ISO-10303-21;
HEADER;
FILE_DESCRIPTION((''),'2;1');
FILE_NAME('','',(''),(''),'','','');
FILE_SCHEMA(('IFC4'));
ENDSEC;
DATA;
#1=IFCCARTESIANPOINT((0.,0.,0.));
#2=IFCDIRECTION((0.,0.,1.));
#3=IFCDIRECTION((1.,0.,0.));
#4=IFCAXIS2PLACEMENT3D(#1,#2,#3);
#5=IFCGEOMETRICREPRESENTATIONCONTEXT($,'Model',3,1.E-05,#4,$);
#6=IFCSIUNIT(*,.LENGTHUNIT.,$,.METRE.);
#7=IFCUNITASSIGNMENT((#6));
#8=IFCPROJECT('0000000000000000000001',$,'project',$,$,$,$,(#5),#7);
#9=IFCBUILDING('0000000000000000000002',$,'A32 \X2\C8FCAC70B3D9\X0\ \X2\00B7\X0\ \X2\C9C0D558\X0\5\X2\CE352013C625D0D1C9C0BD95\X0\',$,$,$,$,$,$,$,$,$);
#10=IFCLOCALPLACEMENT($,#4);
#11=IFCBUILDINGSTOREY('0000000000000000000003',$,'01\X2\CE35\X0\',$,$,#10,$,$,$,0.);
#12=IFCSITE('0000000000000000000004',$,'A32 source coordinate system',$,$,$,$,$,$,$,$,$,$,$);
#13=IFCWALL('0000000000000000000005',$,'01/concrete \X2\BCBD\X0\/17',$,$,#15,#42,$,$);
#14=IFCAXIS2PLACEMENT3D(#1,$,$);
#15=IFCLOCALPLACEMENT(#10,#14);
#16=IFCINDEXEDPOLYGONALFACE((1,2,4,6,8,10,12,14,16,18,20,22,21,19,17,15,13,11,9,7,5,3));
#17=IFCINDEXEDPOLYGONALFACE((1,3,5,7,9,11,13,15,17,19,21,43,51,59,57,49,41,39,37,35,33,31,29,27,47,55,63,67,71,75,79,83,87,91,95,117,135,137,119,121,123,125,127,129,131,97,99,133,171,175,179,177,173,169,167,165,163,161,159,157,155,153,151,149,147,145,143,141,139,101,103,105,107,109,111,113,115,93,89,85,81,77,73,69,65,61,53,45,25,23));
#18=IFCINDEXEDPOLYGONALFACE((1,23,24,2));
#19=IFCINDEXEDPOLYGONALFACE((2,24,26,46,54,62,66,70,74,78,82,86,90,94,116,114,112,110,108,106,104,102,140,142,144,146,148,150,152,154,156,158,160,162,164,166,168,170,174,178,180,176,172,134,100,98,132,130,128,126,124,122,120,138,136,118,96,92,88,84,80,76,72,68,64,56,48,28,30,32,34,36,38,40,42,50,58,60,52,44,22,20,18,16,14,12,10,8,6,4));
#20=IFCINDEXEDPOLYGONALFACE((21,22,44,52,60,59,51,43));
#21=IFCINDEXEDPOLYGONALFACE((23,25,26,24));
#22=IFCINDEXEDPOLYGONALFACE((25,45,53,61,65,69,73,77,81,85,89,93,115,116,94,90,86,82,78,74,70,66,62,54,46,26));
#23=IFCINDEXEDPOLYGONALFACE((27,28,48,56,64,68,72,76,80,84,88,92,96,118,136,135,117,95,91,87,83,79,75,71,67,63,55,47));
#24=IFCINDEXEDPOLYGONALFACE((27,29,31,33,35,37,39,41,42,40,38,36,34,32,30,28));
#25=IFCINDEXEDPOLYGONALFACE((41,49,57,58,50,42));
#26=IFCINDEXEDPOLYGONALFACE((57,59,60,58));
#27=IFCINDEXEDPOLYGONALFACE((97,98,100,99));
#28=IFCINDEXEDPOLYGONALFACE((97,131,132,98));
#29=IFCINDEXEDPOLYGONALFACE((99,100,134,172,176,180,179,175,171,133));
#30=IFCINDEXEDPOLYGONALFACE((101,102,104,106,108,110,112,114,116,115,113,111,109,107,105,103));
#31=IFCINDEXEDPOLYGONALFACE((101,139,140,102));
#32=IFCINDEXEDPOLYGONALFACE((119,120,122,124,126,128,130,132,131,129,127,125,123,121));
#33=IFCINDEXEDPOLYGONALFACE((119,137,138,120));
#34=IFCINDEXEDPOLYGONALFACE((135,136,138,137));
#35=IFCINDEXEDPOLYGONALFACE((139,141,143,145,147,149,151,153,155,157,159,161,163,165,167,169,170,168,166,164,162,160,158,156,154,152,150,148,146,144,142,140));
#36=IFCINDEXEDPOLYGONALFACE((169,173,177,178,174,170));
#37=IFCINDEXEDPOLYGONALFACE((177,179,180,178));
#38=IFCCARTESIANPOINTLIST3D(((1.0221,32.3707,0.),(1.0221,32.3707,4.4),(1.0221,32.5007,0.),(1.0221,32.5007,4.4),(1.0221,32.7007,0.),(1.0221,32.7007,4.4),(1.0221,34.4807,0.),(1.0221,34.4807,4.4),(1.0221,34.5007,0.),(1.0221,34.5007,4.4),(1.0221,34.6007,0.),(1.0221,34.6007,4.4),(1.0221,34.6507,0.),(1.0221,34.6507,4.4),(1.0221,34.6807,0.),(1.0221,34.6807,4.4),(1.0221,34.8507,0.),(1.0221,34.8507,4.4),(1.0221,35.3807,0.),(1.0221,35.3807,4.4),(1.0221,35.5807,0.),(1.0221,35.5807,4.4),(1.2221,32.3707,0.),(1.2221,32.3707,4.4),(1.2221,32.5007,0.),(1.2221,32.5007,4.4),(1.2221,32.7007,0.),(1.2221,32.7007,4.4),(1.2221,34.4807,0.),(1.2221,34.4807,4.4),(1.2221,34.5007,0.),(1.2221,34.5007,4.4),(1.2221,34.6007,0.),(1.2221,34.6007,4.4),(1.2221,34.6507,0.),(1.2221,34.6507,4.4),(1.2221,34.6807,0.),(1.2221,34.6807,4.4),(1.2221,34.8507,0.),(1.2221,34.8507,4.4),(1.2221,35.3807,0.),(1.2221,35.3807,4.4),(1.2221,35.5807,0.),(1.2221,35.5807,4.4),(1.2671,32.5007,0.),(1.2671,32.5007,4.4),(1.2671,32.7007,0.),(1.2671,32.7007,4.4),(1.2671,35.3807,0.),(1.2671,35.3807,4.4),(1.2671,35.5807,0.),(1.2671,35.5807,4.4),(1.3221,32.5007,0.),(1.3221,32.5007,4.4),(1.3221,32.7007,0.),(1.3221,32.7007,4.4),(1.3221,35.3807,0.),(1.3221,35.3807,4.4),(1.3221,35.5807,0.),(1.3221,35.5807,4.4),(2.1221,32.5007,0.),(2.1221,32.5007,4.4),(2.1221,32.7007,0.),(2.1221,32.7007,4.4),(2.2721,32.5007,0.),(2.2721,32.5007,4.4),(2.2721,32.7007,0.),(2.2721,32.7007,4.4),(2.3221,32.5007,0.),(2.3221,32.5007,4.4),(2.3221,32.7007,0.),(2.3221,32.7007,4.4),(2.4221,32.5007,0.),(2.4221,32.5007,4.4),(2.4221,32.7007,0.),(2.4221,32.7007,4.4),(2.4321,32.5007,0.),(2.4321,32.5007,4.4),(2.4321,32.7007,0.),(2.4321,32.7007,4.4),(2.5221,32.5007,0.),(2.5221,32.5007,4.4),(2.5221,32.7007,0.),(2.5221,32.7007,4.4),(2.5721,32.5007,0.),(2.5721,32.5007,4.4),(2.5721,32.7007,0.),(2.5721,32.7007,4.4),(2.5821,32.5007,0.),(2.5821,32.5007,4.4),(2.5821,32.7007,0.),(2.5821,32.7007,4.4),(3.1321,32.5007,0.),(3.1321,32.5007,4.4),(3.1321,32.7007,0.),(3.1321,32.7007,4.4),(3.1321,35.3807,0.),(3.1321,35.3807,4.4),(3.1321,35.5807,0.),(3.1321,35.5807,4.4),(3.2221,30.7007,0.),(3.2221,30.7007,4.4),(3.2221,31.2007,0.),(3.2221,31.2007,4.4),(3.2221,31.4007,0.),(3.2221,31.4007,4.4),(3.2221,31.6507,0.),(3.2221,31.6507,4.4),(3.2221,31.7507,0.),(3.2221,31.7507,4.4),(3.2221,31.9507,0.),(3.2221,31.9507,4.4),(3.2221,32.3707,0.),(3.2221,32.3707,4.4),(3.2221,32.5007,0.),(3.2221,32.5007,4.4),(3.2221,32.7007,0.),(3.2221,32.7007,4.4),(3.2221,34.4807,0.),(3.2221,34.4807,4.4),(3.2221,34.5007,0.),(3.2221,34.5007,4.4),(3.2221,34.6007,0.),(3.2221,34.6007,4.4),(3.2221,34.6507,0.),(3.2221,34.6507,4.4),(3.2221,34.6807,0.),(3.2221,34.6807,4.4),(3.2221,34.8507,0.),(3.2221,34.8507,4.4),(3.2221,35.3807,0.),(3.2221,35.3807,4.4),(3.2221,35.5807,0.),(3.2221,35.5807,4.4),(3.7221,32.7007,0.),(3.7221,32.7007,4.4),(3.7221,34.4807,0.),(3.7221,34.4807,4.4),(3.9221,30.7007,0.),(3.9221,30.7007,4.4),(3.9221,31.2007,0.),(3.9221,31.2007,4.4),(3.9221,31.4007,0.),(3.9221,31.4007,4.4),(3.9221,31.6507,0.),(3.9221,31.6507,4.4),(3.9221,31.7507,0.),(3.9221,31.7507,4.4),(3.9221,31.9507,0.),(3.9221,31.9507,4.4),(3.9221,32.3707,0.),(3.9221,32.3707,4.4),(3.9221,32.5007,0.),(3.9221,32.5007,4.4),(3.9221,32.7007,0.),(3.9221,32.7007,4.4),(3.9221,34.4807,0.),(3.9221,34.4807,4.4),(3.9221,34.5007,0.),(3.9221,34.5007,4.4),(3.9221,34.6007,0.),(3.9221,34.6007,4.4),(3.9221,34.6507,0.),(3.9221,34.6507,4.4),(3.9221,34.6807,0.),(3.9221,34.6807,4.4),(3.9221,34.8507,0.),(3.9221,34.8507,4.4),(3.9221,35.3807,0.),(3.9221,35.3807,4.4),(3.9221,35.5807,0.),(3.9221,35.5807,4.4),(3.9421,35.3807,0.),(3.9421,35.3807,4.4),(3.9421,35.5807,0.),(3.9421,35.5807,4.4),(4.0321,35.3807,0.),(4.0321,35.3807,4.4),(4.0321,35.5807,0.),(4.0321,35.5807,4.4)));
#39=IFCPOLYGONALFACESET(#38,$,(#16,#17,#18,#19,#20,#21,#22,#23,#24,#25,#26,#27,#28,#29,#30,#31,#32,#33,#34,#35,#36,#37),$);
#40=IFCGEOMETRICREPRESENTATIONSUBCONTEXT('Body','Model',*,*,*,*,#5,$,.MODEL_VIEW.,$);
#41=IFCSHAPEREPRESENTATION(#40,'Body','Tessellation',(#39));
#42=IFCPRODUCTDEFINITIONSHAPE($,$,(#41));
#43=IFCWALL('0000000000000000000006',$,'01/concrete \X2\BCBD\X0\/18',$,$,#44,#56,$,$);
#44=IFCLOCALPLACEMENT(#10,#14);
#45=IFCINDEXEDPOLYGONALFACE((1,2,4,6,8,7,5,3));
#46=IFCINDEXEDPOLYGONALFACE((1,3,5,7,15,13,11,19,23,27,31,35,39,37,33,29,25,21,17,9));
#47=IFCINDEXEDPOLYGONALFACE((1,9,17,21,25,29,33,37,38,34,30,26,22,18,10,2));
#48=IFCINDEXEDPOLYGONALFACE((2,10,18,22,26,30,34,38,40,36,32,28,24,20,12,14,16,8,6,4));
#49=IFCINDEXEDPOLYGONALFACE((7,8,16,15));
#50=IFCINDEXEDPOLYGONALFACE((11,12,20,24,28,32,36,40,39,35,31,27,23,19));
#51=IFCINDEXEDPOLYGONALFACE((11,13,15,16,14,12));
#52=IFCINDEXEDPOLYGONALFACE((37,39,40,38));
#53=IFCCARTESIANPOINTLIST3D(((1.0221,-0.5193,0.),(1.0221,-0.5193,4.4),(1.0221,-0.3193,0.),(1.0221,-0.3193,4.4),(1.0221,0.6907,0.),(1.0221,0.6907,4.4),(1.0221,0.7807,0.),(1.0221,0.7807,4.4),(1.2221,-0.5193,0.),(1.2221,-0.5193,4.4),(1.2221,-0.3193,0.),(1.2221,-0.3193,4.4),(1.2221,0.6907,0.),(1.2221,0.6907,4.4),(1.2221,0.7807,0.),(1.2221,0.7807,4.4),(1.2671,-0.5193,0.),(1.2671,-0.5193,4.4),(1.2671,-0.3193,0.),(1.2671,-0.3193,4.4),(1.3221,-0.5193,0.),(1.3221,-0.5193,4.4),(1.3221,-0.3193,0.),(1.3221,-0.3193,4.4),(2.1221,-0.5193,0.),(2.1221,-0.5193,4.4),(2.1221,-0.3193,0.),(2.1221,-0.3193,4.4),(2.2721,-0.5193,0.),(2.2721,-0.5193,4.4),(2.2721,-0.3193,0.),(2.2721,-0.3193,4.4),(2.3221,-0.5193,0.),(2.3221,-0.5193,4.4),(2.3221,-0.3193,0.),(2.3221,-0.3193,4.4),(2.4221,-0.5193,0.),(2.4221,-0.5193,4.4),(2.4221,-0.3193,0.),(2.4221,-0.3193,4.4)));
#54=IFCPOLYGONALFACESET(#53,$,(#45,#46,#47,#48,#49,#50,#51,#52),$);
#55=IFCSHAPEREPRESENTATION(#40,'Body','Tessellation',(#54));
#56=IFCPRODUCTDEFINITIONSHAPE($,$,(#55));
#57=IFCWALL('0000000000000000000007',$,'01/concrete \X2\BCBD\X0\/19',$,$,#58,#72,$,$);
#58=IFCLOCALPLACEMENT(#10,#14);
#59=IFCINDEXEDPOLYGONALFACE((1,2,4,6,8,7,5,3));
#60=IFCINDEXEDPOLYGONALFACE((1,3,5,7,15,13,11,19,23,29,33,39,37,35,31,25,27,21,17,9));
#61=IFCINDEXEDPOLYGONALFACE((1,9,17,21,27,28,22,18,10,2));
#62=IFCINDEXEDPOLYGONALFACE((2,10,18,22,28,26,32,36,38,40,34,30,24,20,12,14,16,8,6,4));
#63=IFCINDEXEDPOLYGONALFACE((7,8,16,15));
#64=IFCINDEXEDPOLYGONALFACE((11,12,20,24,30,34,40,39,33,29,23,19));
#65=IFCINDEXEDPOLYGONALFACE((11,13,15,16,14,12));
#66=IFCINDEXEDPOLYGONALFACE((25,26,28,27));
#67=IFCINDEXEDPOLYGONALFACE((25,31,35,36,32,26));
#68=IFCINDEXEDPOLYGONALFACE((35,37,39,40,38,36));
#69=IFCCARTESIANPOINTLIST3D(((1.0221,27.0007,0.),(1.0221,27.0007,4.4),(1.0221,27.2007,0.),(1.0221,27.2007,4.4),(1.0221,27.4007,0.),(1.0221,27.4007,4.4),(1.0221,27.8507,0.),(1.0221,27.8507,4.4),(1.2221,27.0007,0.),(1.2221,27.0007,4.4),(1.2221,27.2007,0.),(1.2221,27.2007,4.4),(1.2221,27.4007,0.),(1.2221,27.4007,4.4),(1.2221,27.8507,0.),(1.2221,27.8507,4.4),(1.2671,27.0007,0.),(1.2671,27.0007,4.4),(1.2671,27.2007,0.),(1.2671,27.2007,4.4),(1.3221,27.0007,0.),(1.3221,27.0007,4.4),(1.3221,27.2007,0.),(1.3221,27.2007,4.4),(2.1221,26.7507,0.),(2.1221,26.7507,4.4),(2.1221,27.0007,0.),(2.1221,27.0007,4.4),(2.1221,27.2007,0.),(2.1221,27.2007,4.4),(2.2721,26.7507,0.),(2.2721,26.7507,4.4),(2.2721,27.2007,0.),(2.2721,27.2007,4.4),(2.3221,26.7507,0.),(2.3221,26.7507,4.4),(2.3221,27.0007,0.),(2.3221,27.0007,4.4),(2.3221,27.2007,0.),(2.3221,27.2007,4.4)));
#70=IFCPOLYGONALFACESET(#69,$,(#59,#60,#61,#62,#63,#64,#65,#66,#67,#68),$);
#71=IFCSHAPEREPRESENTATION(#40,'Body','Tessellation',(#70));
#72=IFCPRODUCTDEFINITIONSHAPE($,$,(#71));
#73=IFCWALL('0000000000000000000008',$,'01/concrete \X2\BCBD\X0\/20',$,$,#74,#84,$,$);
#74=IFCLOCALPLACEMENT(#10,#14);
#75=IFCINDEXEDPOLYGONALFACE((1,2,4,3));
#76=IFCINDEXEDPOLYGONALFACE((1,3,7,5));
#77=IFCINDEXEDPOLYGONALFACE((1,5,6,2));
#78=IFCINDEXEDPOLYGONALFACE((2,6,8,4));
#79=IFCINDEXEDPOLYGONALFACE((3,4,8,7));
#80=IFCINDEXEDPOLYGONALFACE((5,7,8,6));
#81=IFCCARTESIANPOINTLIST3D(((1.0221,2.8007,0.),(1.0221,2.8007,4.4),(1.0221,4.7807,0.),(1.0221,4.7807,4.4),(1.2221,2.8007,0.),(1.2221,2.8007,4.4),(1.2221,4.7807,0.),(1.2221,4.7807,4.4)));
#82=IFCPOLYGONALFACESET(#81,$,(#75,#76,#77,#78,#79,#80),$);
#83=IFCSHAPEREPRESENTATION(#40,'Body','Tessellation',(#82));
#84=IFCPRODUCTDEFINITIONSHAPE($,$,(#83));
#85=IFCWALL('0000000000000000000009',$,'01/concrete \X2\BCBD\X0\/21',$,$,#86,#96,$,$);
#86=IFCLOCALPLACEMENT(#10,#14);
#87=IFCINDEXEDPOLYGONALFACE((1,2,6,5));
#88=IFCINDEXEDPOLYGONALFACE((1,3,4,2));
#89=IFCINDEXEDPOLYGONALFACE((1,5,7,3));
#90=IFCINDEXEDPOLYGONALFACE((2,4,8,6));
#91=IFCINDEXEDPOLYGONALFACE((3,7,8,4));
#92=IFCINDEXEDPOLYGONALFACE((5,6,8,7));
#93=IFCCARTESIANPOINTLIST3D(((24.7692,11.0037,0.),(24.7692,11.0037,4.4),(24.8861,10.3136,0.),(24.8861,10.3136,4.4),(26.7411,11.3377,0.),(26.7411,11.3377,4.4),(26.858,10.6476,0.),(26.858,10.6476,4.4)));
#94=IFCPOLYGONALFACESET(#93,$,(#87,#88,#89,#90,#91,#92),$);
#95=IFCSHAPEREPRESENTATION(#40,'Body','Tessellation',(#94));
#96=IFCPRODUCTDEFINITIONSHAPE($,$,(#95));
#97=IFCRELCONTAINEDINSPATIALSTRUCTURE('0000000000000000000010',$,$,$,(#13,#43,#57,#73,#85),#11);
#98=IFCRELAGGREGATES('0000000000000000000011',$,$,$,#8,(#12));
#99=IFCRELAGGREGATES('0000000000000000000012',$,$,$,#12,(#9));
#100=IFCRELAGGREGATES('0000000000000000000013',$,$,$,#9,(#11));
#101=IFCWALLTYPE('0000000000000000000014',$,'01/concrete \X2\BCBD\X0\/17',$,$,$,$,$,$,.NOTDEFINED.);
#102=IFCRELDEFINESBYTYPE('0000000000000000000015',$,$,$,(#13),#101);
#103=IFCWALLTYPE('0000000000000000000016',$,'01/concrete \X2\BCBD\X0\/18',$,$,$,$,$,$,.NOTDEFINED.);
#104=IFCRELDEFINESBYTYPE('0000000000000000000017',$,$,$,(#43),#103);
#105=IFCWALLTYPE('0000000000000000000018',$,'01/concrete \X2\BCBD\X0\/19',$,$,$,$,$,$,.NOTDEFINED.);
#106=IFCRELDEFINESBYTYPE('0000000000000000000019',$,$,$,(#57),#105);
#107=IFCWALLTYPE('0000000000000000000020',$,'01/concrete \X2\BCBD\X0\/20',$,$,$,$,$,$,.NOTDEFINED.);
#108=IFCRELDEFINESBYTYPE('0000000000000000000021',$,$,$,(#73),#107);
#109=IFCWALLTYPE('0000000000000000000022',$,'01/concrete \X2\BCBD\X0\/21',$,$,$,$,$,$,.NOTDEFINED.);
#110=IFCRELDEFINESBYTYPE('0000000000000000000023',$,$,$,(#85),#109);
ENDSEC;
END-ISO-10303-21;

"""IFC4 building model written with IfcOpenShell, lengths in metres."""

from ifc_helpers import new_model, si_unit, origin, origin_with_axes, place, context, subcontext, project, spatial, polyline, outline, extrude, source, transform, mapped, type_object, type_shapes, element, save


model = new_model("IFC4")

# Units and contexts
model_context = context("Model", 3, precision=1e-05, world=origin_with_axes())
body_context = subcontext(model_context, "Body", "Model", "MODEL_VIEW")
ifc_project = project(units=[si_unit("LENGTHUNIT", "METRE")], contexts=[model_context])

# Site, building, storey
site = spatial("IfcSite", under=ifc_project, Name="A32 source coordinate system")
building = spatial("IfcBuilding", under=site, Name="A32 주거동 · 지하5층–옥탑지붕")
storey_placement = place(None, origin_with_axes())
storey = spatial("IfcBuildingStorey", under=building, at=storey_placement, Name="01층", Elevation=0.0)

# Walls
wall_type_1 = type_object("IfcWallType", Name="01/concrete 벽/17", PredefinedType="NOTDEFINED")
shared_shape_1 = source(origin(), body_context, "Body", "SweptSolid", [
    extrude(outline(polyline([(1.0221, 34.5007), (1.0221, 34.6007), (1.0221, 34.6507), (1.0221, 34.6807), (1.0221, 34.8507), (1.0221, 35.3807), (1.0221, 35.5807), (1.2221, 35.5807), (1.2671, 35.5807), (1.3221, 35.5807), (1.3221, 35.3807), (1.2671, 35.3807), (1.2221, 35.3807), (1.2221, 34.8507), (1.2221, 34.6807), (1.2221, 34.6507), (1.2221, 34.6007), (1.2221, 34.5007), (1.2221, 34.4807), (1.2221, 32.7007), (1.2671, 32.7007), (1.3221, 32.7007), (2.1221, 32.7007), (2.2721, 32.7007), (2.3221, 32.7007), (2.4221, 32.7007), (2.4321, 32.7007), (2.5221, 32.7007), (2.5721, 32.7007), (2.5821, 32.7007), (3.1321, 32.7007), (3.2221, 32.7007), (3.7221, 32.7007), (3.7221, 34.4807), (3.2221, 34.4807), (3.2221, 34.5007), (3.2221, 34.6007), (3.2221, 34.6507), (3.2221, 34.6807), (3.2221, 34.8507), (3.2221, 35.3807), (3.1321, 35.3807), (3.1321, 35.5807), (3.2221, 35.5807), (3.9221, 35.5807), (3.9421, 35.5807), (4.0321, 35.5807), (4.0321, 35.3807), (3.9421, 35.3807), (3.9221, 35.3807), (3.9221, 34.8507), (3.9221, 34.6807), (3.9221, 34.6507), (3.9221, 34.6007), (3.9221, 34.5007), (3.9221, 34.4807), (3.9221, 32.7007), (3.9221, 32.5007), (3.9221, 32.3707), (3.9221, 31.9507), (3.9221, 31.7507), (3.9221, 31.6507), (3.9221, 31.4007), (3.9221, 31.2007), (3.9221, 30.7007), (3.2221, 30.7007), (3.2221, 31.2007), (3.2221, 31.4007), (3.2221, 31.6507), (3.2221, 31.7507), (3.2221, 31.9507), (3.2221, 32.3707), (3.2221, 32.5007), (3.1321, 32.5007), (2.5821, 32.5007), (2.5721, 32.5007), (2.5221, 32.5007), (2.4321, 32.5007), (2.4221, 32.5007), (2.3221, 32.5007), (2.2721, 32.5007), (2.1221, 32.5007), (1.3221, 32.5007), (1.2671, 32.5007), (1.2221, 32.5007), (1.2221, 32.3707), (1.0221, 32.3707), (1.0221, 32.5007), (1.0221, 32.7007), (1.0221, 34.4807), (1.0221, 34.5007)])), origin(), (0.0, 0.0, 1.0), 4.4),
])
type_shapes(wall_type_1, [shared_shape_1])
wall_1_placement = place(storey_placement, origin_with_axes())
element("IfcWall", 1, at=wall_1_placement, inside=storey, type_object=wall_type_1, Name="01/concrete 벽/17", context=body_context, shape_type="MappedRepresentation", body=[
    mapped(shared_shape_1, transform((0.0, 0.0, 0.0), scale=1.0)),
])
wall_type_2 = type_object("IfcWallType", Name="01/concrete 벽/18", PredefinedType="NOTDEFINED")
shared_shape_2 = source(origin(), body_context, "Body", "SweptSolid", [
    extrude(outline(polyline([(1.0221, -0.5193), (1.0221, -0.3193), (1.0221, 0.6907), (1.0221, 0.7807), (1.2221, 0.7807), (1.2221, 0.6907), (1.2221, -0.3193), (1.2671, -0.3193), (1.3221, -0.3193), (2.1221, -0.3193), (2.2721, -0.3193), (2.3221, -0.3193), (2.4221, -0.3193), (2.4221, -0.5193), (2.3221, -0.5193), (2.2721, -0.5193), (2.1221, -0.5193), (1.3221, -0.5193), (1.2671, -0.5193), (1.2221, -0.5193), (1.0221, -0.5193)])), origin(), (0.0, 0.0, 1.0), 4.4),
])
type_shapes(wall_type_2, [shared_shape_2])
wall_2_placement = place(storey_placement, origin_with_axes())
element("IfcWall", 2, at=wall_2_placement, inside=storey, type_object=wall_type_2, Name="01/concrete 벽/18", context=body_context, shape_type="MappedRepresentation", body=[
    mapped(shared_shape_2, transform((0.0, 0.0, 0.0), scale=1.0)),
])
wall_type_3 = type_object("IfcWallType", Name="01/concrete 벽/19", PredefinedType="NOTDEFINED")
shared_shape_3 = source(origin(), body_context, "Body", "SweptSolid", [
    extrude(outline(polyline([(1.0221, 27.4007), (1.0221, 27.8507), (1.2221, 27.8507), (1.2221, 27.4007), (1.2221, 27.2007), (1.2671, 27.2007), (1.3221, 27.2007), (2.1221, 27.2007), (2.2721, 27.2007), (2.3221, 27.2007), (2.3221, 27.0007), (2.3221, 26.7507), (2.2721, 26.7507), (2.1221, 26.7507), (2.1221, 27.0007), (1.3221, 27.0007), (1.2671, 27.0007), (1.2221, 27.0007), (1.0221, 27.0007), (1.0221, 27.2007), (1.0221, 27.4007)])), origin(), (0.0, 0.0, 1.0), 4.4),
])
type_shapes(wall_type_3, [shared_shape_3])
wall_3_placement = place(storey_placement, origin_with_axes())
element("IfcWall", 3, at=wall_3_placement, inside=storey, type_object=wall_type_3, Name="01/concrete 벽/19", context=body_context, shape_type="MappedRepresentation", body=[
    mapped(shared_shape_3, transform((0.0, 0.0, 0.0), scale=1.0)),
])
wall_type_4 = type_object("IfcWallType", Name="01/concrete 벽/20", PredefinedType="NOTDEFINED")
shared_shape_4 = source(origin(), body_context, "Body", "SweptSolid", [
    extrude(outline(polyline([(1.2221, 2.8007), (1.0221, 2.8007), (1.0221, 4.7807), (1.2221, 4.7807), (1.2221, 2.8007)])), origin(), (0.0, 0.0, 1.0), 4.4),
])
type_shapes(wall_type_4, [shared_shape_4])
wall_4_placement = place(storey_placement, origin_with_axes())
element("IfcWall", 4, at=wall_4_placement, inside=storey, type_object=wall_type_4, Name="01/concrete 벽/20", context=body_context, shape_type="MappedRepresentation", body=[
    mapped(shared_shape_4, transform((0.0, 0.0, 0.0), scale=1.0)),
])
wall_type_5 = type_object("IfcWallType", Name="01/concrete 벽/21", PredefinedType="NOTDEFINED")
shared_shape_5 = source(origin(), body_context, "Body", "SweptSolid", [
    extrude(outline(polyline([(24.8861, 10.3136), (24.7692, 11.0037), (26.7411, 11.3377), (26.858, 10.6476), (24.8861, 10.3136)])), origin(), (0.0, 0.0, 1.0), 4.4),
])
type_shapes(wall_type_5, [shared_shape_5])
wall_5_placement = place(storey_placement, origin_with_axes())
element("IfcWall", 5, at=wall_5_placement, inside=storey, type_object=wall_type_5, Name="01/concrete 벽/21", context=body_context, shape_type="MappedRepresentation", body=[
    mapped(shared_shape_5, transform((0.0, 0.0, 0.0), scale=1.0)),
])

save(model, "model.ifc")
